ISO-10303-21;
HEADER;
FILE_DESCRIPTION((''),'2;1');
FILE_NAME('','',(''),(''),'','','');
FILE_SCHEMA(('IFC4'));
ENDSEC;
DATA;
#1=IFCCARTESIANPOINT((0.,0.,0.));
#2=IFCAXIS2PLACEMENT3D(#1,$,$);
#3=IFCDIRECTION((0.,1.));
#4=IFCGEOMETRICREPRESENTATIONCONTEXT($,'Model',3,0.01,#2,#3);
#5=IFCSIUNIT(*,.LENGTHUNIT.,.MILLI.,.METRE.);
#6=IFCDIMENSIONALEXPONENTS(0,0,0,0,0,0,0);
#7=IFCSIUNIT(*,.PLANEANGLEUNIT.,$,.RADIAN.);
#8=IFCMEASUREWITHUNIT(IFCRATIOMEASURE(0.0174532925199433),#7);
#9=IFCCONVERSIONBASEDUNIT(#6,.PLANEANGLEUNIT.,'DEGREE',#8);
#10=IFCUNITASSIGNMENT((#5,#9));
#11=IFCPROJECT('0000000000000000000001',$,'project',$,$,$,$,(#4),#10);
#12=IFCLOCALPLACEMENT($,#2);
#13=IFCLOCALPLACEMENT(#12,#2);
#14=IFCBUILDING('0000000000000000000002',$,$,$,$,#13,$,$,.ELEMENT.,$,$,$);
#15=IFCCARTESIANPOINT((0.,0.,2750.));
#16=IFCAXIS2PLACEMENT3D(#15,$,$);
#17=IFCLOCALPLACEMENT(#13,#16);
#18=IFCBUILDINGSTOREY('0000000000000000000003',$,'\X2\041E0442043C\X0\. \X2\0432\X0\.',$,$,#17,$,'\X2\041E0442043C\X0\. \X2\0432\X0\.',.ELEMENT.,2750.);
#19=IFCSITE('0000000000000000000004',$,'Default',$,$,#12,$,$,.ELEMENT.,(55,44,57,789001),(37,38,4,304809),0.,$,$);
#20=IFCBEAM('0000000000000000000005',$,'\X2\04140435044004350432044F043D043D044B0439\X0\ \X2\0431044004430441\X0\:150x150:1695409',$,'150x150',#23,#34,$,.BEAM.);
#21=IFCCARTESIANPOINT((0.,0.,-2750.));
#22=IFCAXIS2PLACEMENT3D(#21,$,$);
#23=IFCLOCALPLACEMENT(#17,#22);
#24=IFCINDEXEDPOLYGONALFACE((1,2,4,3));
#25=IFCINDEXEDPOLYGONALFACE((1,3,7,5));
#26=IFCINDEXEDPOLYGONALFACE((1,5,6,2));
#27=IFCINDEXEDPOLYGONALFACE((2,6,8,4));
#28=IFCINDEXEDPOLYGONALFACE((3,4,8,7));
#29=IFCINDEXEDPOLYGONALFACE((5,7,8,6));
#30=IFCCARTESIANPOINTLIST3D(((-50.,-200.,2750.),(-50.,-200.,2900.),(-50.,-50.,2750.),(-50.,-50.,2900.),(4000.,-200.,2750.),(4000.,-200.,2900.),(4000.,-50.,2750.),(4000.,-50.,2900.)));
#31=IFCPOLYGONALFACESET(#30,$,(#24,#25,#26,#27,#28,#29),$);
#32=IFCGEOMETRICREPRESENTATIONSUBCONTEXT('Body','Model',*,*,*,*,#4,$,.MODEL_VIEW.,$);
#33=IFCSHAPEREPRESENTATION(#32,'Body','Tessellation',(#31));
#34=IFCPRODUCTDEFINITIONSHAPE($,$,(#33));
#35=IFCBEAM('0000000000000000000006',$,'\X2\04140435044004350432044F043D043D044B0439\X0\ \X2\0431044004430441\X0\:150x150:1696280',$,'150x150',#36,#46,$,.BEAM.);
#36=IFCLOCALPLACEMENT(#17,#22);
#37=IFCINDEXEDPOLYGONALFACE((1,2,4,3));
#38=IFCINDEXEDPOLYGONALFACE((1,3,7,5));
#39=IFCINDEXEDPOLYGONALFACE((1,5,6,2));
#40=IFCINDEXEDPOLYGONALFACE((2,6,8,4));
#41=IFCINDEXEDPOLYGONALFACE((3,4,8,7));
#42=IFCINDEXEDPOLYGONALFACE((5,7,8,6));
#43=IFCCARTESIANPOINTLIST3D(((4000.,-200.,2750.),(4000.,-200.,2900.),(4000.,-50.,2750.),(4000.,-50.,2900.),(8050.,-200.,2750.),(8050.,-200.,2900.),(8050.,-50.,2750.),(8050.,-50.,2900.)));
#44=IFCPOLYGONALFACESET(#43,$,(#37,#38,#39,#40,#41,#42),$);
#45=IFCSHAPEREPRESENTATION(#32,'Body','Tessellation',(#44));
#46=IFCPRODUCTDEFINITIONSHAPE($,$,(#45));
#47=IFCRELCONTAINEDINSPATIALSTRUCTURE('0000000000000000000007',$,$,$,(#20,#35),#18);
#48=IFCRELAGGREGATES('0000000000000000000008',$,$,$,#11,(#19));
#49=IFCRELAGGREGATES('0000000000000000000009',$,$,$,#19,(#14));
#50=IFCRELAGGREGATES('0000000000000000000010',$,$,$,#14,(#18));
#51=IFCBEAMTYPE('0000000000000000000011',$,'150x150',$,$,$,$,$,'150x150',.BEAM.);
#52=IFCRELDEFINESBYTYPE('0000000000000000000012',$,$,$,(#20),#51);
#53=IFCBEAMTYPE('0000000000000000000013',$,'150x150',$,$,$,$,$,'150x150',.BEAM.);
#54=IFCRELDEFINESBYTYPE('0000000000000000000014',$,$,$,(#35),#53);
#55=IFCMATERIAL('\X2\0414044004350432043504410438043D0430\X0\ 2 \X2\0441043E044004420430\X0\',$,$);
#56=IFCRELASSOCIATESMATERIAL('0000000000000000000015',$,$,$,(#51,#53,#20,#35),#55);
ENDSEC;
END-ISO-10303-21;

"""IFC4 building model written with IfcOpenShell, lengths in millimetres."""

from ifc_helpers import new_model, entity, si_unit, converted_unit, direction, frame, frame_2d, origin, place, context, subcontext, project, spatial, rectangle, extrude, source, transform, mapped, material, material_profile, profile_set, profile_usage, type_object, type_shapes, element, save


model = new_model("IFC4")

# Units and contexts
model_context = context("Model", 3, precision=0.01, world=origin(), true_north=direction((0.0, 1.0)))
body_context = subcontext(model_context, "Body", "Model", "MODEL_VIEW")
ifc_project = project(units=[si_unit("LENGTHUNIT", "METRE", prefix="MILLI"), converted_unit("PLANEANGLEUNIT", "DEGREE", entity("IfcRatioMeasure", 0.0174532925199433), si_unit("PLANEANGLEUNIT", "RADIAN"), dimensions=[0, 0, 0, 0, 0, 0, 0])], contexts=[model_context])

# Site, building, storey
site_placement = place(None, origin())
site = spatial("IfcSite", under=ifc_project, at=site_placement, Name="Default", CompositionType="ELEMENT", RefLatitude=(55, 44, 57, 789001), RefLongitude=(37, 38, 4, 304809), RefElevation=0.0)
building_placement = place(site_placement, origin())
building = spatial("IfcBuilding", under=site, at=building_placement, CompositionType="ELEMENT")
storey_placement = place(building_placement, frame((0.0, 0.0, 2750.0)))
storey = spatial("IfcBuildingStorey", under=building, at=storey_placement, Name="Отм. в.", LongName="Отм. в.", CompositionType="ELEMENT", Elevation=2750.0)

# Beams
ifc_material_1 = material(Name="Древесина 2 сорта")
ifc_material_profile_1 = material_profile(ifc_material_1, rectangle(XDim=150.0, YDim=2960.0, at=frame_2d((0.0, 0.0), x_axis=(0.0, 1.0))))
ifc_profile_set_1 = profile_set([ifc_material_profile_1], Name="150x150")
ifc_profile_usage_1 = profile_usage(ifc_profile_set_1)
beam_type_1 = type_object("IfcBeamType", Name="150x150", ElementType="150x150", PredefinedType="BEAM", material=ifc_profile_set_1)
shared_shape_1 = source(origin(), body_context, "Body", "SweptSolid", [
    extrude(rectangle(XDim=150.0, YDim=150.0, at=frame_2d((0.0, 0.0), x_axis=(1.0, 0.0))), frame((4000.0, -125.0, 2825.0), z_axis=(-1.0, 0.0, 0.0), x_axis=(0.0, 0.0, -1.0)), (0.0, 0.0, 1.0), 4050.0),
])
type_shapes(beam_type_1, [shared_shape_1])
beam_1_placement = place(storey_placement, frame((0.0, 0.0, -2750.0)))
element("IfcBeam", 1, at=beam_1_placement, inside=storey, type_object=beam_type_1, material=ifc_profile_usage_1, Name="Деревянный брус:150x150:1695409", ObjectType="150x150", PredefinedType="BEAM", context=body_context, shape_type="MappedRepresentation", body=[
    mapped(shared_shape_1, transform((0.0, 0.0, 0.0), scale=1.0)),
])
ifc_profile_usage_2 = profile_usage(ifc_profile_set_1)
beam_type_2 = type_object("IfcBeamType", Name="150x150", ElementType="150x150", PredefinedType="BEAM", material=ifc_profile_set_1)
shared_shape_2 = source(origin(), body_context, "Body", "SweptSolid", [
    extrude(rectangle(XDim=150.0, YDim=150.0, at=frame_2d((0.0, 0.0), x_axis=(1.0, 0.0))), frame((8050.0, -125.0, 2825.0), z_axis=(-1.0, 0.0, 0.0), x_axis=(0.0, 0.0, -1.0)), (0.0, 0.0, 1.0), 4050.0),
])
type_shapes(beam_type_2, [shared_shape_2])
beam_2_placement = place(storey_placement, frame((0.0, 0.0, -2750.0)))
element("IfcBeam", 2, at=beam_2_placement, inside=storey, type_object=beam_type_2, material=ifc_profile_usage_2, Name="Деревянный брус:150x150:1696280", ObjectType="150x150", PredefinedType="BEAM", context=body_context, shape_type="MappedRepresentation", body=[
    mapped(shared_shape_2, transform((0.0, 0.0, 0.0), scale=1.0)),
])

save(model, "model.ifc")
